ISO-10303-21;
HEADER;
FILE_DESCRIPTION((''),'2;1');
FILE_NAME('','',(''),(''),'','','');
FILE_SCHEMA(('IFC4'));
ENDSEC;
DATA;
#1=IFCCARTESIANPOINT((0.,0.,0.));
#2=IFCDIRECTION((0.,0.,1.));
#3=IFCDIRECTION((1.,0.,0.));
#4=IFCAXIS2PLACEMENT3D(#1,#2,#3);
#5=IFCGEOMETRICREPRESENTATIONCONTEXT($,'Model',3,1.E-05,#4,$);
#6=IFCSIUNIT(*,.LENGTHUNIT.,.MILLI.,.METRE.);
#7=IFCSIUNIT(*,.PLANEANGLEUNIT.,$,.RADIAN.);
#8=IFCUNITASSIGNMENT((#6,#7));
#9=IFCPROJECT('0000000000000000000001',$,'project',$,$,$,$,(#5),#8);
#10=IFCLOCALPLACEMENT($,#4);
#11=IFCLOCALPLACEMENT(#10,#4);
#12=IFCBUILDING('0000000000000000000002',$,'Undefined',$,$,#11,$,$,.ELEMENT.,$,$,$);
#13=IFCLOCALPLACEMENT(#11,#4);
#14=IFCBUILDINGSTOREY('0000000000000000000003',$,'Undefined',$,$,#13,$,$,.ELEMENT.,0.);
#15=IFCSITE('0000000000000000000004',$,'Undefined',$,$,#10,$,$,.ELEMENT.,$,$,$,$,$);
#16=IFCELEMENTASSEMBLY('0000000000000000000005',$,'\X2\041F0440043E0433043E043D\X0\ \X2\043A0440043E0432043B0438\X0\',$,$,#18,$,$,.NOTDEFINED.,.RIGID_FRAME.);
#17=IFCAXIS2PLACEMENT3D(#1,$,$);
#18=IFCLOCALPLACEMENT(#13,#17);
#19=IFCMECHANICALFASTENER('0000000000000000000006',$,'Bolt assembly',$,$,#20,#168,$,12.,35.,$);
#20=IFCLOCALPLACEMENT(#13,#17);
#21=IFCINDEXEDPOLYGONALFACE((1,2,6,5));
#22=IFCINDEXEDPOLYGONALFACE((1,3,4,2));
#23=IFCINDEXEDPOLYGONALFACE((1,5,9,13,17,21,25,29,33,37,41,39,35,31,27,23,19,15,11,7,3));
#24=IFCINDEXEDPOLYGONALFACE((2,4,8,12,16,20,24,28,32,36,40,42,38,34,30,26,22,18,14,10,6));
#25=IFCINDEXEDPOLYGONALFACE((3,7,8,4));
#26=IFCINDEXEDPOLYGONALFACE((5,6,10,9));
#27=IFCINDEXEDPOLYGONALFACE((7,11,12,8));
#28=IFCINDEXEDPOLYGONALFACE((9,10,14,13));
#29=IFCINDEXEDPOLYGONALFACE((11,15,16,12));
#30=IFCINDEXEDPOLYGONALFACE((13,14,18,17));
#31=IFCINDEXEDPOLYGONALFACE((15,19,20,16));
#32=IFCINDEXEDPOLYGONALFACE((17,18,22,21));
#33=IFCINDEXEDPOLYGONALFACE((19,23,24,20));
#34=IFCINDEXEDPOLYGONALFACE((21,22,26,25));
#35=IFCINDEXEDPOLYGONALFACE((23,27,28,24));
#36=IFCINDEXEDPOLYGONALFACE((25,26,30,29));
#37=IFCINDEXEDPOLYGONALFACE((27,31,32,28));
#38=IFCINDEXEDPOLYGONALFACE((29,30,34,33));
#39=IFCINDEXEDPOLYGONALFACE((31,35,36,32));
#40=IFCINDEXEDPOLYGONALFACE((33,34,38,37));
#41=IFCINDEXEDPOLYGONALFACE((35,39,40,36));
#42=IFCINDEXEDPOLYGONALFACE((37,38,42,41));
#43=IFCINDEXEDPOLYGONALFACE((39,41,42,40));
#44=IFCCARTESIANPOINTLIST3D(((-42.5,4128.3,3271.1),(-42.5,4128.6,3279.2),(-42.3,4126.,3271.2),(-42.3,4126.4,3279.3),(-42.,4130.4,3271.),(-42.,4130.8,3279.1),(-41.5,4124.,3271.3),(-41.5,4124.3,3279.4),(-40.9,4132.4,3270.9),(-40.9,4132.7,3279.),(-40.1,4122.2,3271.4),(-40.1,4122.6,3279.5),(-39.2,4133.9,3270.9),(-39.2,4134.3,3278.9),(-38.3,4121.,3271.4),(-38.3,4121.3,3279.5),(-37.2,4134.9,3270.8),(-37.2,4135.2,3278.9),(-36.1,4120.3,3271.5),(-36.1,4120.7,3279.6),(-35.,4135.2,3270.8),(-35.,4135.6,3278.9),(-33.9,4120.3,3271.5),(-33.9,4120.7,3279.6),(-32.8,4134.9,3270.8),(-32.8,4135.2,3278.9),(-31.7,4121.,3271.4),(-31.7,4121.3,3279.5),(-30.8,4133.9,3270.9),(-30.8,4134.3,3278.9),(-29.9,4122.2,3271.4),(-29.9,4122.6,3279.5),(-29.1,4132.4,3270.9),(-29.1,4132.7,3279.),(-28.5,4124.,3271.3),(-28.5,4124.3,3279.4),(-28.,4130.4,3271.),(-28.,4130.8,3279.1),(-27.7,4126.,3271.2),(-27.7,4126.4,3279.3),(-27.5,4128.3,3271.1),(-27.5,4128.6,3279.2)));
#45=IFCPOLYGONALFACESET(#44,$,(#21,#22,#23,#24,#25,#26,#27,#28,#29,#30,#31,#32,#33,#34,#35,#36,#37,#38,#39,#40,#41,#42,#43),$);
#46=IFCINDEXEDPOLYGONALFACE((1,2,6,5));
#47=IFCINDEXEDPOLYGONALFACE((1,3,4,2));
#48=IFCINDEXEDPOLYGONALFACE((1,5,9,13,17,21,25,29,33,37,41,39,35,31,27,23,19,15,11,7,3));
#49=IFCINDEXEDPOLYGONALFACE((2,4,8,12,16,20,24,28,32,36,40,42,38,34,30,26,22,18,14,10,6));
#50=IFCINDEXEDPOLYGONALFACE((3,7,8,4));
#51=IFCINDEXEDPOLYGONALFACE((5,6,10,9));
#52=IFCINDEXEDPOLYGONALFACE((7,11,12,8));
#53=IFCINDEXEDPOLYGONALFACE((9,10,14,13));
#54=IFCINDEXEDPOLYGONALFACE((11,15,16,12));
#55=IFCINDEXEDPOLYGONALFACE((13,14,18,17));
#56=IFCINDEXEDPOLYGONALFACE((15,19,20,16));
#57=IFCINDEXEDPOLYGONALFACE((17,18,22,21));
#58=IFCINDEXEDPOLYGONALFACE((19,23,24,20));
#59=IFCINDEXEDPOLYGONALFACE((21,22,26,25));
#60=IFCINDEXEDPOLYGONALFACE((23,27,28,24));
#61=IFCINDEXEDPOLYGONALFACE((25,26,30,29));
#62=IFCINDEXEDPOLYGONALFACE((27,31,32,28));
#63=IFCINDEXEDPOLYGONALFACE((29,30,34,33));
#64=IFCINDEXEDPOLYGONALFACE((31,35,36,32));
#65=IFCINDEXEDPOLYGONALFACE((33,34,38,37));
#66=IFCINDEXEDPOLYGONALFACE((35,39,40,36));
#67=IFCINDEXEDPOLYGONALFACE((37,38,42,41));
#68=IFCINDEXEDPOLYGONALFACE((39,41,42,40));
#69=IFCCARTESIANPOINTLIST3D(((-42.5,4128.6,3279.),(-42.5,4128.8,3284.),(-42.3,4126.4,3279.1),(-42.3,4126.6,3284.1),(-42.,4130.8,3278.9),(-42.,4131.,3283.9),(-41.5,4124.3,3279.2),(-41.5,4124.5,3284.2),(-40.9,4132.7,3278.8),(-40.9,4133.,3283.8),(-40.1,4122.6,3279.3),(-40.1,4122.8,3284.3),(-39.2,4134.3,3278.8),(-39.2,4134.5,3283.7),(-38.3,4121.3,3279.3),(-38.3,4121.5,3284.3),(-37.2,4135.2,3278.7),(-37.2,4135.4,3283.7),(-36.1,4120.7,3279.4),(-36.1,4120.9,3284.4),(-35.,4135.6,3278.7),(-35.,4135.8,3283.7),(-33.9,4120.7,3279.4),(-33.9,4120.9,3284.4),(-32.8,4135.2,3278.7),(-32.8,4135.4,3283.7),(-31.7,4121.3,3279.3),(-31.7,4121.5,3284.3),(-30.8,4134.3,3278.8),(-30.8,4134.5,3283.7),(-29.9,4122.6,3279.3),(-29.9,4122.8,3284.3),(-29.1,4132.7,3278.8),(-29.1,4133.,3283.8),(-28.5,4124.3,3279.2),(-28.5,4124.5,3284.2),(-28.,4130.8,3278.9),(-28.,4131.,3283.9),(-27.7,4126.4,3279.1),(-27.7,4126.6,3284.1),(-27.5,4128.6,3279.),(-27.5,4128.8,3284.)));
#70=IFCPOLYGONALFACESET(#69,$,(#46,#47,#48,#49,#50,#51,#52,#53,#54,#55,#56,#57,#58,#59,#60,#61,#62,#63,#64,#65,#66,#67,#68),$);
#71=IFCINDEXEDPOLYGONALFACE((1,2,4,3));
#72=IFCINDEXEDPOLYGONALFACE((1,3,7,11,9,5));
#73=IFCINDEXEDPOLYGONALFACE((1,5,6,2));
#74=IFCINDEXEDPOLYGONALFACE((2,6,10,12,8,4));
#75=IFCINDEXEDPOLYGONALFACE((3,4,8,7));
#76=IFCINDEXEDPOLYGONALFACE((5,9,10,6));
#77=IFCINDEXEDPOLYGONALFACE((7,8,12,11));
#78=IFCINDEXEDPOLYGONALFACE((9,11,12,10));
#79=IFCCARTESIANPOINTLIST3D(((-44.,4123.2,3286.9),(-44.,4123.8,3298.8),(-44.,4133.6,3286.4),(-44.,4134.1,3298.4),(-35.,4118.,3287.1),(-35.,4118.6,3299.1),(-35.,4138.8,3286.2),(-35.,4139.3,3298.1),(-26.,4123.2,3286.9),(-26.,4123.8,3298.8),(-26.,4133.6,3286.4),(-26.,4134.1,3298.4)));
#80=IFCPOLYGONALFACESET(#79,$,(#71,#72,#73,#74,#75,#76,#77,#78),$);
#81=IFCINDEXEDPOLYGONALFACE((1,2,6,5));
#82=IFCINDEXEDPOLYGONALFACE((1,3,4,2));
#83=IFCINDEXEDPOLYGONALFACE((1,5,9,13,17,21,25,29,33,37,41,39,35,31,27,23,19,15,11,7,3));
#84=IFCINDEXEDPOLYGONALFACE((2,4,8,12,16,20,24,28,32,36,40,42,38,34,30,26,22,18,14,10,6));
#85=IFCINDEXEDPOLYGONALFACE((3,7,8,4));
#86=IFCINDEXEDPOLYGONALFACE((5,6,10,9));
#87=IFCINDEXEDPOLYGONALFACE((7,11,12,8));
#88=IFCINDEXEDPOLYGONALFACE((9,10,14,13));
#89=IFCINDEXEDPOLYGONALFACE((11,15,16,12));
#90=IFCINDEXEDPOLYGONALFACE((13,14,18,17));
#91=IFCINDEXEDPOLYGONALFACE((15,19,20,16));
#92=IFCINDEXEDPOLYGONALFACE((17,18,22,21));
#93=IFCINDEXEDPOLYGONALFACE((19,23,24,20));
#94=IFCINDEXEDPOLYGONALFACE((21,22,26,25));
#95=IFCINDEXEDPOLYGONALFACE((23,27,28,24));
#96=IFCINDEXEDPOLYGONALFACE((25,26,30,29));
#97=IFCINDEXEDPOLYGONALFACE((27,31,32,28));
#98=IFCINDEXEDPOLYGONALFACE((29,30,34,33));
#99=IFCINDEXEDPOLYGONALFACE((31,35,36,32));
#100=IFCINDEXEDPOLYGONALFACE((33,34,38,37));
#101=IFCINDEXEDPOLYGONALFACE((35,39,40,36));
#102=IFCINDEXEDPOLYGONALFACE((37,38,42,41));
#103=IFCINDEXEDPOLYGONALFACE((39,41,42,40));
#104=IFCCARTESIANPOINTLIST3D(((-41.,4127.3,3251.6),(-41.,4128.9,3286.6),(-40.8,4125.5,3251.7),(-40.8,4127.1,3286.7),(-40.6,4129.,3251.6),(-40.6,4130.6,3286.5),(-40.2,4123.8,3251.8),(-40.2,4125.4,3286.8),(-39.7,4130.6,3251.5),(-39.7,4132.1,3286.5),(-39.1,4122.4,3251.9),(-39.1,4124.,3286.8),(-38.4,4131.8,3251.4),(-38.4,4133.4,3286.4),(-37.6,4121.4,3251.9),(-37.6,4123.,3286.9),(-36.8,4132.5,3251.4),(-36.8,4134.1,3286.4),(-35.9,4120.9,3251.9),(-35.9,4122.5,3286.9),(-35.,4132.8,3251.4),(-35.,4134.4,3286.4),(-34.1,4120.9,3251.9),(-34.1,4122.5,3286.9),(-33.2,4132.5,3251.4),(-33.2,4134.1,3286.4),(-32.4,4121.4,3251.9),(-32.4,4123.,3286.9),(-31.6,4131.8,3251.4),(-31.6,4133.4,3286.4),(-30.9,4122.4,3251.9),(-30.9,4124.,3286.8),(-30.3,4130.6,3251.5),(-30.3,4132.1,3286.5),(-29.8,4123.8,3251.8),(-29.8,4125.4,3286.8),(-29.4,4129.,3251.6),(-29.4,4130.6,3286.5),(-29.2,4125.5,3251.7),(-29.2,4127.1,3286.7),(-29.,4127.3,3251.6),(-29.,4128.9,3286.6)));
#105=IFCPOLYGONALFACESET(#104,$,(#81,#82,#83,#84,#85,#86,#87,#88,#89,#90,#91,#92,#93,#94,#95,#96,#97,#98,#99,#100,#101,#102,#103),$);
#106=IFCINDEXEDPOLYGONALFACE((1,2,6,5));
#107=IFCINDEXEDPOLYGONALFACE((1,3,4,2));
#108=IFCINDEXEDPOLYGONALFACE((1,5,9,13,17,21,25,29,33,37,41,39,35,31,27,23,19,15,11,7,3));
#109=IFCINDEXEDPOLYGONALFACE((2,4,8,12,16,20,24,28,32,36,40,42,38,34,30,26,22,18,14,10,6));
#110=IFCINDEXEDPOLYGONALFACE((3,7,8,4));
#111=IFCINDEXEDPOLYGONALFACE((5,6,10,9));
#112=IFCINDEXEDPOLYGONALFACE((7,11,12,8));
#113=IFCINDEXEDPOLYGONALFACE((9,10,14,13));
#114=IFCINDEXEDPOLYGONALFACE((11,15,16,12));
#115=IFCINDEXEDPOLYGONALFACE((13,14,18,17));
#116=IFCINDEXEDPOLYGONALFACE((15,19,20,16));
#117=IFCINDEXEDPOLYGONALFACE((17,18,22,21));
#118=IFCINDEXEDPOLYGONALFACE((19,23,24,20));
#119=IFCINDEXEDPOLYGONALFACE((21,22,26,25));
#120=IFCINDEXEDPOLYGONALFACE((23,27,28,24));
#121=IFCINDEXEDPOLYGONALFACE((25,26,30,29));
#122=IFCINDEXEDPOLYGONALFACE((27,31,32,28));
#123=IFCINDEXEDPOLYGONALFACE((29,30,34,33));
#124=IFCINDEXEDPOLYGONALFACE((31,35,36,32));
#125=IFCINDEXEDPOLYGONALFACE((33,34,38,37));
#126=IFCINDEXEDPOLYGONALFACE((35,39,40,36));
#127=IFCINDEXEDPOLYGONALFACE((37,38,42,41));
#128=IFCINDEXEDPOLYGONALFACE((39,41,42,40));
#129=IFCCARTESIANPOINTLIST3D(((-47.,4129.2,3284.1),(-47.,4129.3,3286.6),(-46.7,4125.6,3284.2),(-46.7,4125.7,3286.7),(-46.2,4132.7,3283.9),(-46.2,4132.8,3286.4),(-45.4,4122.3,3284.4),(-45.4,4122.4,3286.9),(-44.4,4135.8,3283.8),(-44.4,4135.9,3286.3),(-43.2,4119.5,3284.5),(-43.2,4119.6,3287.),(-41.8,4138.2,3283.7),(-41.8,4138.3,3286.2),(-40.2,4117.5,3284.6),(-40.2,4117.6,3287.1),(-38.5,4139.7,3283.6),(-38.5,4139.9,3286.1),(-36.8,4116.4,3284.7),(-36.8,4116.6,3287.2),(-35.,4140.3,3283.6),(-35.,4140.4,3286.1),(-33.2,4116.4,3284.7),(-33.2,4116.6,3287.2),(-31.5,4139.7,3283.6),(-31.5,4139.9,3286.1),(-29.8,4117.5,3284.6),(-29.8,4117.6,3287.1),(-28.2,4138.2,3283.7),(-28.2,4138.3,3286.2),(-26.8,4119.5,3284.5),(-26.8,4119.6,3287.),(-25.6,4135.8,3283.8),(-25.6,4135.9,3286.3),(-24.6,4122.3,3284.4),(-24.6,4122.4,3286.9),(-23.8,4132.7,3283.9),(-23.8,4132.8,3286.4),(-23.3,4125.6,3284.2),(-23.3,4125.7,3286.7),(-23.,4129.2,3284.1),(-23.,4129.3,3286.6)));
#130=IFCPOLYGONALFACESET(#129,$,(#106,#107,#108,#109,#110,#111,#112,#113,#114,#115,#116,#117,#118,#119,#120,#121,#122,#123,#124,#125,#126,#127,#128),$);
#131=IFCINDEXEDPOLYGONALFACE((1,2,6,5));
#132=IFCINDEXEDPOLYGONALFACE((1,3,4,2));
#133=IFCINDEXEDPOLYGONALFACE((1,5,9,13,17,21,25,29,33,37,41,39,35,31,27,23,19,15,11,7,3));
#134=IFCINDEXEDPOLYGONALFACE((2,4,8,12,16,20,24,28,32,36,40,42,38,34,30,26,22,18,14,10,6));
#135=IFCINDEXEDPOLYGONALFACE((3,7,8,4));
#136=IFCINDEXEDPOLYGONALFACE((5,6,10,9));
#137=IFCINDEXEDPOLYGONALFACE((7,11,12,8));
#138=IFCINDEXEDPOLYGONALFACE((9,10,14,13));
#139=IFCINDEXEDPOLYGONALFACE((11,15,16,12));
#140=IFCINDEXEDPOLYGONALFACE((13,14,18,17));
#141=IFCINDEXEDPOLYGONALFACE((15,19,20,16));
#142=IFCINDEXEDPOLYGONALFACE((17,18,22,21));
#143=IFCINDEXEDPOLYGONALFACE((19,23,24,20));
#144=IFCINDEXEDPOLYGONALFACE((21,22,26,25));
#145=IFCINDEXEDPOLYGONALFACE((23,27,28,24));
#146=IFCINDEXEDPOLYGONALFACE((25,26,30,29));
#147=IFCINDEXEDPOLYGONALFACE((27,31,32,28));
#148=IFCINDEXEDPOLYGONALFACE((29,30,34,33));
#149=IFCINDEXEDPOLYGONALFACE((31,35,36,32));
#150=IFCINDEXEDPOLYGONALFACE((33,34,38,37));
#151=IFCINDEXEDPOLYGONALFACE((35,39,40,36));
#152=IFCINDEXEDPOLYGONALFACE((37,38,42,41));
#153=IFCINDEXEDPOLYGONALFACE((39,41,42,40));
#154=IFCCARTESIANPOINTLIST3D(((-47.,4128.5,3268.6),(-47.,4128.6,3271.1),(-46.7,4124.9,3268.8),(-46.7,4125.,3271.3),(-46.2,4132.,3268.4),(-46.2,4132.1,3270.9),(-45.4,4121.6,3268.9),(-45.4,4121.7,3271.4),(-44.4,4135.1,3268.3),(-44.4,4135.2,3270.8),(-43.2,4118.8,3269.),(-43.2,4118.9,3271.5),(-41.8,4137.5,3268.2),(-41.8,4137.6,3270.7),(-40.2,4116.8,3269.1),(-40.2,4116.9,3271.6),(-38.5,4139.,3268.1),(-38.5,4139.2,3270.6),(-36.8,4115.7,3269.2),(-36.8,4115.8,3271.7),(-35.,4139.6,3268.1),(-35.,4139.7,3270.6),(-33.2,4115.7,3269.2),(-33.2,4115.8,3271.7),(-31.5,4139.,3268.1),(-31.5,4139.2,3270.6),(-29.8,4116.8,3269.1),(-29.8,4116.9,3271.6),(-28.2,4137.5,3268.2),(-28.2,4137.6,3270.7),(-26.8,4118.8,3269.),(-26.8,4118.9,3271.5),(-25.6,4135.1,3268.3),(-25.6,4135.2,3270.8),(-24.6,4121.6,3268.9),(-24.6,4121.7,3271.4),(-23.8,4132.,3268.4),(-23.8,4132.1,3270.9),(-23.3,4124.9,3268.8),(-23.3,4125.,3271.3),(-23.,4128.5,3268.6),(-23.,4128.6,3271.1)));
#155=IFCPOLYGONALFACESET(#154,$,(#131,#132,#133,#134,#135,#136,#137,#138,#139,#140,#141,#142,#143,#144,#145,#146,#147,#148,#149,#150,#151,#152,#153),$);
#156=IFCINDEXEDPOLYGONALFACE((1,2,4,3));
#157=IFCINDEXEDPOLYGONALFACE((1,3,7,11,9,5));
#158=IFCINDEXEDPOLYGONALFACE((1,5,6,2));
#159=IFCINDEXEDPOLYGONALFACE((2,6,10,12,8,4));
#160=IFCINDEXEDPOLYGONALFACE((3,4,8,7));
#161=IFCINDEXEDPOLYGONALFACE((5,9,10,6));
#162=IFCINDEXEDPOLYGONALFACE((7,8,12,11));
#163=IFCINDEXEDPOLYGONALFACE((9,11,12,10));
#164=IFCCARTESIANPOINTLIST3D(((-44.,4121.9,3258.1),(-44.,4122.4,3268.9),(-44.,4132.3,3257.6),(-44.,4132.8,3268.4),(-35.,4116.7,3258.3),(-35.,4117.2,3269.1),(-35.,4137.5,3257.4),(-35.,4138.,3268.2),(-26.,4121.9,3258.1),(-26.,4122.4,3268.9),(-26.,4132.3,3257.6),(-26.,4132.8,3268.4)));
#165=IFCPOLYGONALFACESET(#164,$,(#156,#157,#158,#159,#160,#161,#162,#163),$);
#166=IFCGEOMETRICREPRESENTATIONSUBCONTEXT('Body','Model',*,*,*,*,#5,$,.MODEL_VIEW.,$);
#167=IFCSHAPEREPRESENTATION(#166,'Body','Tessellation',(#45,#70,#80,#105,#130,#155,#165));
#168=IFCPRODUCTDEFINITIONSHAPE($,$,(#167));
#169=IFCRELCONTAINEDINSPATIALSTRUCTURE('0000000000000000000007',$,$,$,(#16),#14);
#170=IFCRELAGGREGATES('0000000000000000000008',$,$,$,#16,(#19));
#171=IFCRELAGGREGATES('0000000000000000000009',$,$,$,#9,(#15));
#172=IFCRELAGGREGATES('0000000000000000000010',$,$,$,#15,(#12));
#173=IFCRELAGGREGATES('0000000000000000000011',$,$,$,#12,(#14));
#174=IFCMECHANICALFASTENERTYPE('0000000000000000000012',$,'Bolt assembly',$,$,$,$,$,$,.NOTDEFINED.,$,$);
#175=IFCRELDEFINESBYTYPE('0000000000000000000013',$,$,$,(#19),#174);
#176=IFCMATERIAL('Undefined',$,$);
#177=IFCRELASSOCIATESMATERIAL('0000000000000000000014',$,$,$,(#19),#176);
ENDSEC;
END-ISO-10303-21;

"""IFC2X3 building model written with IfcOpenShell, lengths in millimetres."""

from ifc_helpers import new_model, si_unit, frame, origin_with_axes, origin_2d_with_axis, place, context, subcontext, project, spatial, polyline, circle, outline, extrude, source, transform, mapped, material, type_object, element, aggregate, save


model = new_model("IFC2X3")

# Units and contexts
model_context = context("Model", 3, precision=1e-05, world=origin_with_axes())
body_context = subcontext(model_context, "Body", "Model", "MODEL_VIEW")
ifc_project = project(units=[si_unit("LENGTHUNIT", "METRE", prefix="MILLI"), si_unit("PLANEANGLEUNIT", "RADIAN")], contexts=[model_context])

# Site, building, storey
site_placement = place(None, origin_with_axes())
site = spatial("IfcSite", under=ifc_project, at=site_placement, Name="Undefined", CompositionType="ELEMENT")
building_placement = place(site_placement, origin_with_axes())
building = spatial("IfcBuilding", under=site, at=building_placement, Name="Undefined", CompositionType="ELEMENT")
storey_placement = place(building_placement, origin_with_axes())
storey = spatial("IfcBuildingStorey", under=building, at=storey_placement, Name="Undefined", CompositionType="ELEMENT", Elevation=0.0)

# Element assembly
assembly_1_placement = place(storey_placement, origin_with_axes())
assembly_1 = element("IfcElementAssembly", 1, at=assembly_1_placement, inside=storey, Name="Прогон кровли", AssemblyPlace="NOTDEFINED", PredefinedType="RIGID_FRAME")

# Mechanical fastener
ifc_material_1 = material(Name="Undefined")
mechanical_fastener_type = type_object("IfcMechanicalFastenerType", Name="Bolt assembly")
shared_shape_1 = source(origin_with_axes(), body_context, "Body", "SweptSolid", [
    extrude(circle(Radius=7.5, at=origin_2d_with_axis()), frame((0.0, -0.1, 0.0), z_axis=(0.0, 1.0, 0.0), x_axis=(1.0, 0.0, 0.0)), (0.0, 0.0, 1.0), 8.1),
    extrude(circle(Radius=7.5, at=origin_2d_with_axis()), frame((0.0, -4.9, 0.0), z_axis=(0.0, 1.0, 0.0), x_axis=(1.0, 0.0, 0.0)), (0.0, 0.0, 1.0), 5.0),
    extrude(outline(polyline([(10.4, 0.0), (5.2, 9.0), (-5.2, 9.0), (-10.4, 0.0), (-5.2, -9.0), (5.2, -9.0), (10.4, 0.0)])), frame((0.0, -19.5, 0.0), z_axis=(0.0, 1.0, 0.0), x_axis=(1.0, 0.0, 0.0)), (0.0, 0.0, 1.0), 12.0),
    extrude(circle(Radius=6.0, at=origin_2d_with_axis()), frame((0.0, -7.5, 0.0), z_axis=(0.0, 1.0, 0.0), x_axis=(1.0, 0.0, 0.0)), (0.0, 0.0, 1.0), 35.0),
    extrude(circle(Radius=12.0, at=origin_2d_with_axis()), frame((0.0, -7.5, 0.0), z_axis=(0.0, 1.0, 0.0), x_axis=(1.0, 0.0, 0.0)), (0.0, 0.0, 1.0), 2.5),
    extrude(circle(Radius=12.0, at=origin_2d_with_axis()), frame((0.0, 8.0, 0.0), z_axis=(0.0, 1.0, 0.0), x_axis=(1.0, 0.0, 0.0)), (0.0, 0.0, 1.0), 2.5),
    extrude(outline(polyline([(10.4, 0.0), (5.2, 9.0), (-5.2, 9.0), (-10.4, 0.0), (-5.2, -9.0), (5.2, -9.0), (10.4, 0.0)])), frame((0.0, 10.5, 0.0), z_axis=(0.0, 1.0, 0.0), x_axis=(1.0, 0.0, 0.0)), (0.0, 0.0, 1.0), 10.8),
])
mechanical_fastener_1_placement = place(assembly_1_placement, frame((-35.0, 4128.1, 3279.1), z_axis=(-1.0, 0.0, 0.0), x_axis=(0.0, 0.998969, -0.045408)))
mechanical_fastener_1 = element("IfcMechanicalFastener", 2, at=mechanical_fastener_1_placement, type_object=mechanical_fastener_type, material=ifc_material_1, Name="Bolt assembly", NominalDiameter=12.0, NominalLength=35.0, context=body_context, shape_type="MappedRepresentation", body=[
    mapped(shared_shape_1, transform((0.0, 0.0, 0.0))),
])
aggregate(assembly_1, [mechanical_fastener_1])

save(model, "model.ifc")
